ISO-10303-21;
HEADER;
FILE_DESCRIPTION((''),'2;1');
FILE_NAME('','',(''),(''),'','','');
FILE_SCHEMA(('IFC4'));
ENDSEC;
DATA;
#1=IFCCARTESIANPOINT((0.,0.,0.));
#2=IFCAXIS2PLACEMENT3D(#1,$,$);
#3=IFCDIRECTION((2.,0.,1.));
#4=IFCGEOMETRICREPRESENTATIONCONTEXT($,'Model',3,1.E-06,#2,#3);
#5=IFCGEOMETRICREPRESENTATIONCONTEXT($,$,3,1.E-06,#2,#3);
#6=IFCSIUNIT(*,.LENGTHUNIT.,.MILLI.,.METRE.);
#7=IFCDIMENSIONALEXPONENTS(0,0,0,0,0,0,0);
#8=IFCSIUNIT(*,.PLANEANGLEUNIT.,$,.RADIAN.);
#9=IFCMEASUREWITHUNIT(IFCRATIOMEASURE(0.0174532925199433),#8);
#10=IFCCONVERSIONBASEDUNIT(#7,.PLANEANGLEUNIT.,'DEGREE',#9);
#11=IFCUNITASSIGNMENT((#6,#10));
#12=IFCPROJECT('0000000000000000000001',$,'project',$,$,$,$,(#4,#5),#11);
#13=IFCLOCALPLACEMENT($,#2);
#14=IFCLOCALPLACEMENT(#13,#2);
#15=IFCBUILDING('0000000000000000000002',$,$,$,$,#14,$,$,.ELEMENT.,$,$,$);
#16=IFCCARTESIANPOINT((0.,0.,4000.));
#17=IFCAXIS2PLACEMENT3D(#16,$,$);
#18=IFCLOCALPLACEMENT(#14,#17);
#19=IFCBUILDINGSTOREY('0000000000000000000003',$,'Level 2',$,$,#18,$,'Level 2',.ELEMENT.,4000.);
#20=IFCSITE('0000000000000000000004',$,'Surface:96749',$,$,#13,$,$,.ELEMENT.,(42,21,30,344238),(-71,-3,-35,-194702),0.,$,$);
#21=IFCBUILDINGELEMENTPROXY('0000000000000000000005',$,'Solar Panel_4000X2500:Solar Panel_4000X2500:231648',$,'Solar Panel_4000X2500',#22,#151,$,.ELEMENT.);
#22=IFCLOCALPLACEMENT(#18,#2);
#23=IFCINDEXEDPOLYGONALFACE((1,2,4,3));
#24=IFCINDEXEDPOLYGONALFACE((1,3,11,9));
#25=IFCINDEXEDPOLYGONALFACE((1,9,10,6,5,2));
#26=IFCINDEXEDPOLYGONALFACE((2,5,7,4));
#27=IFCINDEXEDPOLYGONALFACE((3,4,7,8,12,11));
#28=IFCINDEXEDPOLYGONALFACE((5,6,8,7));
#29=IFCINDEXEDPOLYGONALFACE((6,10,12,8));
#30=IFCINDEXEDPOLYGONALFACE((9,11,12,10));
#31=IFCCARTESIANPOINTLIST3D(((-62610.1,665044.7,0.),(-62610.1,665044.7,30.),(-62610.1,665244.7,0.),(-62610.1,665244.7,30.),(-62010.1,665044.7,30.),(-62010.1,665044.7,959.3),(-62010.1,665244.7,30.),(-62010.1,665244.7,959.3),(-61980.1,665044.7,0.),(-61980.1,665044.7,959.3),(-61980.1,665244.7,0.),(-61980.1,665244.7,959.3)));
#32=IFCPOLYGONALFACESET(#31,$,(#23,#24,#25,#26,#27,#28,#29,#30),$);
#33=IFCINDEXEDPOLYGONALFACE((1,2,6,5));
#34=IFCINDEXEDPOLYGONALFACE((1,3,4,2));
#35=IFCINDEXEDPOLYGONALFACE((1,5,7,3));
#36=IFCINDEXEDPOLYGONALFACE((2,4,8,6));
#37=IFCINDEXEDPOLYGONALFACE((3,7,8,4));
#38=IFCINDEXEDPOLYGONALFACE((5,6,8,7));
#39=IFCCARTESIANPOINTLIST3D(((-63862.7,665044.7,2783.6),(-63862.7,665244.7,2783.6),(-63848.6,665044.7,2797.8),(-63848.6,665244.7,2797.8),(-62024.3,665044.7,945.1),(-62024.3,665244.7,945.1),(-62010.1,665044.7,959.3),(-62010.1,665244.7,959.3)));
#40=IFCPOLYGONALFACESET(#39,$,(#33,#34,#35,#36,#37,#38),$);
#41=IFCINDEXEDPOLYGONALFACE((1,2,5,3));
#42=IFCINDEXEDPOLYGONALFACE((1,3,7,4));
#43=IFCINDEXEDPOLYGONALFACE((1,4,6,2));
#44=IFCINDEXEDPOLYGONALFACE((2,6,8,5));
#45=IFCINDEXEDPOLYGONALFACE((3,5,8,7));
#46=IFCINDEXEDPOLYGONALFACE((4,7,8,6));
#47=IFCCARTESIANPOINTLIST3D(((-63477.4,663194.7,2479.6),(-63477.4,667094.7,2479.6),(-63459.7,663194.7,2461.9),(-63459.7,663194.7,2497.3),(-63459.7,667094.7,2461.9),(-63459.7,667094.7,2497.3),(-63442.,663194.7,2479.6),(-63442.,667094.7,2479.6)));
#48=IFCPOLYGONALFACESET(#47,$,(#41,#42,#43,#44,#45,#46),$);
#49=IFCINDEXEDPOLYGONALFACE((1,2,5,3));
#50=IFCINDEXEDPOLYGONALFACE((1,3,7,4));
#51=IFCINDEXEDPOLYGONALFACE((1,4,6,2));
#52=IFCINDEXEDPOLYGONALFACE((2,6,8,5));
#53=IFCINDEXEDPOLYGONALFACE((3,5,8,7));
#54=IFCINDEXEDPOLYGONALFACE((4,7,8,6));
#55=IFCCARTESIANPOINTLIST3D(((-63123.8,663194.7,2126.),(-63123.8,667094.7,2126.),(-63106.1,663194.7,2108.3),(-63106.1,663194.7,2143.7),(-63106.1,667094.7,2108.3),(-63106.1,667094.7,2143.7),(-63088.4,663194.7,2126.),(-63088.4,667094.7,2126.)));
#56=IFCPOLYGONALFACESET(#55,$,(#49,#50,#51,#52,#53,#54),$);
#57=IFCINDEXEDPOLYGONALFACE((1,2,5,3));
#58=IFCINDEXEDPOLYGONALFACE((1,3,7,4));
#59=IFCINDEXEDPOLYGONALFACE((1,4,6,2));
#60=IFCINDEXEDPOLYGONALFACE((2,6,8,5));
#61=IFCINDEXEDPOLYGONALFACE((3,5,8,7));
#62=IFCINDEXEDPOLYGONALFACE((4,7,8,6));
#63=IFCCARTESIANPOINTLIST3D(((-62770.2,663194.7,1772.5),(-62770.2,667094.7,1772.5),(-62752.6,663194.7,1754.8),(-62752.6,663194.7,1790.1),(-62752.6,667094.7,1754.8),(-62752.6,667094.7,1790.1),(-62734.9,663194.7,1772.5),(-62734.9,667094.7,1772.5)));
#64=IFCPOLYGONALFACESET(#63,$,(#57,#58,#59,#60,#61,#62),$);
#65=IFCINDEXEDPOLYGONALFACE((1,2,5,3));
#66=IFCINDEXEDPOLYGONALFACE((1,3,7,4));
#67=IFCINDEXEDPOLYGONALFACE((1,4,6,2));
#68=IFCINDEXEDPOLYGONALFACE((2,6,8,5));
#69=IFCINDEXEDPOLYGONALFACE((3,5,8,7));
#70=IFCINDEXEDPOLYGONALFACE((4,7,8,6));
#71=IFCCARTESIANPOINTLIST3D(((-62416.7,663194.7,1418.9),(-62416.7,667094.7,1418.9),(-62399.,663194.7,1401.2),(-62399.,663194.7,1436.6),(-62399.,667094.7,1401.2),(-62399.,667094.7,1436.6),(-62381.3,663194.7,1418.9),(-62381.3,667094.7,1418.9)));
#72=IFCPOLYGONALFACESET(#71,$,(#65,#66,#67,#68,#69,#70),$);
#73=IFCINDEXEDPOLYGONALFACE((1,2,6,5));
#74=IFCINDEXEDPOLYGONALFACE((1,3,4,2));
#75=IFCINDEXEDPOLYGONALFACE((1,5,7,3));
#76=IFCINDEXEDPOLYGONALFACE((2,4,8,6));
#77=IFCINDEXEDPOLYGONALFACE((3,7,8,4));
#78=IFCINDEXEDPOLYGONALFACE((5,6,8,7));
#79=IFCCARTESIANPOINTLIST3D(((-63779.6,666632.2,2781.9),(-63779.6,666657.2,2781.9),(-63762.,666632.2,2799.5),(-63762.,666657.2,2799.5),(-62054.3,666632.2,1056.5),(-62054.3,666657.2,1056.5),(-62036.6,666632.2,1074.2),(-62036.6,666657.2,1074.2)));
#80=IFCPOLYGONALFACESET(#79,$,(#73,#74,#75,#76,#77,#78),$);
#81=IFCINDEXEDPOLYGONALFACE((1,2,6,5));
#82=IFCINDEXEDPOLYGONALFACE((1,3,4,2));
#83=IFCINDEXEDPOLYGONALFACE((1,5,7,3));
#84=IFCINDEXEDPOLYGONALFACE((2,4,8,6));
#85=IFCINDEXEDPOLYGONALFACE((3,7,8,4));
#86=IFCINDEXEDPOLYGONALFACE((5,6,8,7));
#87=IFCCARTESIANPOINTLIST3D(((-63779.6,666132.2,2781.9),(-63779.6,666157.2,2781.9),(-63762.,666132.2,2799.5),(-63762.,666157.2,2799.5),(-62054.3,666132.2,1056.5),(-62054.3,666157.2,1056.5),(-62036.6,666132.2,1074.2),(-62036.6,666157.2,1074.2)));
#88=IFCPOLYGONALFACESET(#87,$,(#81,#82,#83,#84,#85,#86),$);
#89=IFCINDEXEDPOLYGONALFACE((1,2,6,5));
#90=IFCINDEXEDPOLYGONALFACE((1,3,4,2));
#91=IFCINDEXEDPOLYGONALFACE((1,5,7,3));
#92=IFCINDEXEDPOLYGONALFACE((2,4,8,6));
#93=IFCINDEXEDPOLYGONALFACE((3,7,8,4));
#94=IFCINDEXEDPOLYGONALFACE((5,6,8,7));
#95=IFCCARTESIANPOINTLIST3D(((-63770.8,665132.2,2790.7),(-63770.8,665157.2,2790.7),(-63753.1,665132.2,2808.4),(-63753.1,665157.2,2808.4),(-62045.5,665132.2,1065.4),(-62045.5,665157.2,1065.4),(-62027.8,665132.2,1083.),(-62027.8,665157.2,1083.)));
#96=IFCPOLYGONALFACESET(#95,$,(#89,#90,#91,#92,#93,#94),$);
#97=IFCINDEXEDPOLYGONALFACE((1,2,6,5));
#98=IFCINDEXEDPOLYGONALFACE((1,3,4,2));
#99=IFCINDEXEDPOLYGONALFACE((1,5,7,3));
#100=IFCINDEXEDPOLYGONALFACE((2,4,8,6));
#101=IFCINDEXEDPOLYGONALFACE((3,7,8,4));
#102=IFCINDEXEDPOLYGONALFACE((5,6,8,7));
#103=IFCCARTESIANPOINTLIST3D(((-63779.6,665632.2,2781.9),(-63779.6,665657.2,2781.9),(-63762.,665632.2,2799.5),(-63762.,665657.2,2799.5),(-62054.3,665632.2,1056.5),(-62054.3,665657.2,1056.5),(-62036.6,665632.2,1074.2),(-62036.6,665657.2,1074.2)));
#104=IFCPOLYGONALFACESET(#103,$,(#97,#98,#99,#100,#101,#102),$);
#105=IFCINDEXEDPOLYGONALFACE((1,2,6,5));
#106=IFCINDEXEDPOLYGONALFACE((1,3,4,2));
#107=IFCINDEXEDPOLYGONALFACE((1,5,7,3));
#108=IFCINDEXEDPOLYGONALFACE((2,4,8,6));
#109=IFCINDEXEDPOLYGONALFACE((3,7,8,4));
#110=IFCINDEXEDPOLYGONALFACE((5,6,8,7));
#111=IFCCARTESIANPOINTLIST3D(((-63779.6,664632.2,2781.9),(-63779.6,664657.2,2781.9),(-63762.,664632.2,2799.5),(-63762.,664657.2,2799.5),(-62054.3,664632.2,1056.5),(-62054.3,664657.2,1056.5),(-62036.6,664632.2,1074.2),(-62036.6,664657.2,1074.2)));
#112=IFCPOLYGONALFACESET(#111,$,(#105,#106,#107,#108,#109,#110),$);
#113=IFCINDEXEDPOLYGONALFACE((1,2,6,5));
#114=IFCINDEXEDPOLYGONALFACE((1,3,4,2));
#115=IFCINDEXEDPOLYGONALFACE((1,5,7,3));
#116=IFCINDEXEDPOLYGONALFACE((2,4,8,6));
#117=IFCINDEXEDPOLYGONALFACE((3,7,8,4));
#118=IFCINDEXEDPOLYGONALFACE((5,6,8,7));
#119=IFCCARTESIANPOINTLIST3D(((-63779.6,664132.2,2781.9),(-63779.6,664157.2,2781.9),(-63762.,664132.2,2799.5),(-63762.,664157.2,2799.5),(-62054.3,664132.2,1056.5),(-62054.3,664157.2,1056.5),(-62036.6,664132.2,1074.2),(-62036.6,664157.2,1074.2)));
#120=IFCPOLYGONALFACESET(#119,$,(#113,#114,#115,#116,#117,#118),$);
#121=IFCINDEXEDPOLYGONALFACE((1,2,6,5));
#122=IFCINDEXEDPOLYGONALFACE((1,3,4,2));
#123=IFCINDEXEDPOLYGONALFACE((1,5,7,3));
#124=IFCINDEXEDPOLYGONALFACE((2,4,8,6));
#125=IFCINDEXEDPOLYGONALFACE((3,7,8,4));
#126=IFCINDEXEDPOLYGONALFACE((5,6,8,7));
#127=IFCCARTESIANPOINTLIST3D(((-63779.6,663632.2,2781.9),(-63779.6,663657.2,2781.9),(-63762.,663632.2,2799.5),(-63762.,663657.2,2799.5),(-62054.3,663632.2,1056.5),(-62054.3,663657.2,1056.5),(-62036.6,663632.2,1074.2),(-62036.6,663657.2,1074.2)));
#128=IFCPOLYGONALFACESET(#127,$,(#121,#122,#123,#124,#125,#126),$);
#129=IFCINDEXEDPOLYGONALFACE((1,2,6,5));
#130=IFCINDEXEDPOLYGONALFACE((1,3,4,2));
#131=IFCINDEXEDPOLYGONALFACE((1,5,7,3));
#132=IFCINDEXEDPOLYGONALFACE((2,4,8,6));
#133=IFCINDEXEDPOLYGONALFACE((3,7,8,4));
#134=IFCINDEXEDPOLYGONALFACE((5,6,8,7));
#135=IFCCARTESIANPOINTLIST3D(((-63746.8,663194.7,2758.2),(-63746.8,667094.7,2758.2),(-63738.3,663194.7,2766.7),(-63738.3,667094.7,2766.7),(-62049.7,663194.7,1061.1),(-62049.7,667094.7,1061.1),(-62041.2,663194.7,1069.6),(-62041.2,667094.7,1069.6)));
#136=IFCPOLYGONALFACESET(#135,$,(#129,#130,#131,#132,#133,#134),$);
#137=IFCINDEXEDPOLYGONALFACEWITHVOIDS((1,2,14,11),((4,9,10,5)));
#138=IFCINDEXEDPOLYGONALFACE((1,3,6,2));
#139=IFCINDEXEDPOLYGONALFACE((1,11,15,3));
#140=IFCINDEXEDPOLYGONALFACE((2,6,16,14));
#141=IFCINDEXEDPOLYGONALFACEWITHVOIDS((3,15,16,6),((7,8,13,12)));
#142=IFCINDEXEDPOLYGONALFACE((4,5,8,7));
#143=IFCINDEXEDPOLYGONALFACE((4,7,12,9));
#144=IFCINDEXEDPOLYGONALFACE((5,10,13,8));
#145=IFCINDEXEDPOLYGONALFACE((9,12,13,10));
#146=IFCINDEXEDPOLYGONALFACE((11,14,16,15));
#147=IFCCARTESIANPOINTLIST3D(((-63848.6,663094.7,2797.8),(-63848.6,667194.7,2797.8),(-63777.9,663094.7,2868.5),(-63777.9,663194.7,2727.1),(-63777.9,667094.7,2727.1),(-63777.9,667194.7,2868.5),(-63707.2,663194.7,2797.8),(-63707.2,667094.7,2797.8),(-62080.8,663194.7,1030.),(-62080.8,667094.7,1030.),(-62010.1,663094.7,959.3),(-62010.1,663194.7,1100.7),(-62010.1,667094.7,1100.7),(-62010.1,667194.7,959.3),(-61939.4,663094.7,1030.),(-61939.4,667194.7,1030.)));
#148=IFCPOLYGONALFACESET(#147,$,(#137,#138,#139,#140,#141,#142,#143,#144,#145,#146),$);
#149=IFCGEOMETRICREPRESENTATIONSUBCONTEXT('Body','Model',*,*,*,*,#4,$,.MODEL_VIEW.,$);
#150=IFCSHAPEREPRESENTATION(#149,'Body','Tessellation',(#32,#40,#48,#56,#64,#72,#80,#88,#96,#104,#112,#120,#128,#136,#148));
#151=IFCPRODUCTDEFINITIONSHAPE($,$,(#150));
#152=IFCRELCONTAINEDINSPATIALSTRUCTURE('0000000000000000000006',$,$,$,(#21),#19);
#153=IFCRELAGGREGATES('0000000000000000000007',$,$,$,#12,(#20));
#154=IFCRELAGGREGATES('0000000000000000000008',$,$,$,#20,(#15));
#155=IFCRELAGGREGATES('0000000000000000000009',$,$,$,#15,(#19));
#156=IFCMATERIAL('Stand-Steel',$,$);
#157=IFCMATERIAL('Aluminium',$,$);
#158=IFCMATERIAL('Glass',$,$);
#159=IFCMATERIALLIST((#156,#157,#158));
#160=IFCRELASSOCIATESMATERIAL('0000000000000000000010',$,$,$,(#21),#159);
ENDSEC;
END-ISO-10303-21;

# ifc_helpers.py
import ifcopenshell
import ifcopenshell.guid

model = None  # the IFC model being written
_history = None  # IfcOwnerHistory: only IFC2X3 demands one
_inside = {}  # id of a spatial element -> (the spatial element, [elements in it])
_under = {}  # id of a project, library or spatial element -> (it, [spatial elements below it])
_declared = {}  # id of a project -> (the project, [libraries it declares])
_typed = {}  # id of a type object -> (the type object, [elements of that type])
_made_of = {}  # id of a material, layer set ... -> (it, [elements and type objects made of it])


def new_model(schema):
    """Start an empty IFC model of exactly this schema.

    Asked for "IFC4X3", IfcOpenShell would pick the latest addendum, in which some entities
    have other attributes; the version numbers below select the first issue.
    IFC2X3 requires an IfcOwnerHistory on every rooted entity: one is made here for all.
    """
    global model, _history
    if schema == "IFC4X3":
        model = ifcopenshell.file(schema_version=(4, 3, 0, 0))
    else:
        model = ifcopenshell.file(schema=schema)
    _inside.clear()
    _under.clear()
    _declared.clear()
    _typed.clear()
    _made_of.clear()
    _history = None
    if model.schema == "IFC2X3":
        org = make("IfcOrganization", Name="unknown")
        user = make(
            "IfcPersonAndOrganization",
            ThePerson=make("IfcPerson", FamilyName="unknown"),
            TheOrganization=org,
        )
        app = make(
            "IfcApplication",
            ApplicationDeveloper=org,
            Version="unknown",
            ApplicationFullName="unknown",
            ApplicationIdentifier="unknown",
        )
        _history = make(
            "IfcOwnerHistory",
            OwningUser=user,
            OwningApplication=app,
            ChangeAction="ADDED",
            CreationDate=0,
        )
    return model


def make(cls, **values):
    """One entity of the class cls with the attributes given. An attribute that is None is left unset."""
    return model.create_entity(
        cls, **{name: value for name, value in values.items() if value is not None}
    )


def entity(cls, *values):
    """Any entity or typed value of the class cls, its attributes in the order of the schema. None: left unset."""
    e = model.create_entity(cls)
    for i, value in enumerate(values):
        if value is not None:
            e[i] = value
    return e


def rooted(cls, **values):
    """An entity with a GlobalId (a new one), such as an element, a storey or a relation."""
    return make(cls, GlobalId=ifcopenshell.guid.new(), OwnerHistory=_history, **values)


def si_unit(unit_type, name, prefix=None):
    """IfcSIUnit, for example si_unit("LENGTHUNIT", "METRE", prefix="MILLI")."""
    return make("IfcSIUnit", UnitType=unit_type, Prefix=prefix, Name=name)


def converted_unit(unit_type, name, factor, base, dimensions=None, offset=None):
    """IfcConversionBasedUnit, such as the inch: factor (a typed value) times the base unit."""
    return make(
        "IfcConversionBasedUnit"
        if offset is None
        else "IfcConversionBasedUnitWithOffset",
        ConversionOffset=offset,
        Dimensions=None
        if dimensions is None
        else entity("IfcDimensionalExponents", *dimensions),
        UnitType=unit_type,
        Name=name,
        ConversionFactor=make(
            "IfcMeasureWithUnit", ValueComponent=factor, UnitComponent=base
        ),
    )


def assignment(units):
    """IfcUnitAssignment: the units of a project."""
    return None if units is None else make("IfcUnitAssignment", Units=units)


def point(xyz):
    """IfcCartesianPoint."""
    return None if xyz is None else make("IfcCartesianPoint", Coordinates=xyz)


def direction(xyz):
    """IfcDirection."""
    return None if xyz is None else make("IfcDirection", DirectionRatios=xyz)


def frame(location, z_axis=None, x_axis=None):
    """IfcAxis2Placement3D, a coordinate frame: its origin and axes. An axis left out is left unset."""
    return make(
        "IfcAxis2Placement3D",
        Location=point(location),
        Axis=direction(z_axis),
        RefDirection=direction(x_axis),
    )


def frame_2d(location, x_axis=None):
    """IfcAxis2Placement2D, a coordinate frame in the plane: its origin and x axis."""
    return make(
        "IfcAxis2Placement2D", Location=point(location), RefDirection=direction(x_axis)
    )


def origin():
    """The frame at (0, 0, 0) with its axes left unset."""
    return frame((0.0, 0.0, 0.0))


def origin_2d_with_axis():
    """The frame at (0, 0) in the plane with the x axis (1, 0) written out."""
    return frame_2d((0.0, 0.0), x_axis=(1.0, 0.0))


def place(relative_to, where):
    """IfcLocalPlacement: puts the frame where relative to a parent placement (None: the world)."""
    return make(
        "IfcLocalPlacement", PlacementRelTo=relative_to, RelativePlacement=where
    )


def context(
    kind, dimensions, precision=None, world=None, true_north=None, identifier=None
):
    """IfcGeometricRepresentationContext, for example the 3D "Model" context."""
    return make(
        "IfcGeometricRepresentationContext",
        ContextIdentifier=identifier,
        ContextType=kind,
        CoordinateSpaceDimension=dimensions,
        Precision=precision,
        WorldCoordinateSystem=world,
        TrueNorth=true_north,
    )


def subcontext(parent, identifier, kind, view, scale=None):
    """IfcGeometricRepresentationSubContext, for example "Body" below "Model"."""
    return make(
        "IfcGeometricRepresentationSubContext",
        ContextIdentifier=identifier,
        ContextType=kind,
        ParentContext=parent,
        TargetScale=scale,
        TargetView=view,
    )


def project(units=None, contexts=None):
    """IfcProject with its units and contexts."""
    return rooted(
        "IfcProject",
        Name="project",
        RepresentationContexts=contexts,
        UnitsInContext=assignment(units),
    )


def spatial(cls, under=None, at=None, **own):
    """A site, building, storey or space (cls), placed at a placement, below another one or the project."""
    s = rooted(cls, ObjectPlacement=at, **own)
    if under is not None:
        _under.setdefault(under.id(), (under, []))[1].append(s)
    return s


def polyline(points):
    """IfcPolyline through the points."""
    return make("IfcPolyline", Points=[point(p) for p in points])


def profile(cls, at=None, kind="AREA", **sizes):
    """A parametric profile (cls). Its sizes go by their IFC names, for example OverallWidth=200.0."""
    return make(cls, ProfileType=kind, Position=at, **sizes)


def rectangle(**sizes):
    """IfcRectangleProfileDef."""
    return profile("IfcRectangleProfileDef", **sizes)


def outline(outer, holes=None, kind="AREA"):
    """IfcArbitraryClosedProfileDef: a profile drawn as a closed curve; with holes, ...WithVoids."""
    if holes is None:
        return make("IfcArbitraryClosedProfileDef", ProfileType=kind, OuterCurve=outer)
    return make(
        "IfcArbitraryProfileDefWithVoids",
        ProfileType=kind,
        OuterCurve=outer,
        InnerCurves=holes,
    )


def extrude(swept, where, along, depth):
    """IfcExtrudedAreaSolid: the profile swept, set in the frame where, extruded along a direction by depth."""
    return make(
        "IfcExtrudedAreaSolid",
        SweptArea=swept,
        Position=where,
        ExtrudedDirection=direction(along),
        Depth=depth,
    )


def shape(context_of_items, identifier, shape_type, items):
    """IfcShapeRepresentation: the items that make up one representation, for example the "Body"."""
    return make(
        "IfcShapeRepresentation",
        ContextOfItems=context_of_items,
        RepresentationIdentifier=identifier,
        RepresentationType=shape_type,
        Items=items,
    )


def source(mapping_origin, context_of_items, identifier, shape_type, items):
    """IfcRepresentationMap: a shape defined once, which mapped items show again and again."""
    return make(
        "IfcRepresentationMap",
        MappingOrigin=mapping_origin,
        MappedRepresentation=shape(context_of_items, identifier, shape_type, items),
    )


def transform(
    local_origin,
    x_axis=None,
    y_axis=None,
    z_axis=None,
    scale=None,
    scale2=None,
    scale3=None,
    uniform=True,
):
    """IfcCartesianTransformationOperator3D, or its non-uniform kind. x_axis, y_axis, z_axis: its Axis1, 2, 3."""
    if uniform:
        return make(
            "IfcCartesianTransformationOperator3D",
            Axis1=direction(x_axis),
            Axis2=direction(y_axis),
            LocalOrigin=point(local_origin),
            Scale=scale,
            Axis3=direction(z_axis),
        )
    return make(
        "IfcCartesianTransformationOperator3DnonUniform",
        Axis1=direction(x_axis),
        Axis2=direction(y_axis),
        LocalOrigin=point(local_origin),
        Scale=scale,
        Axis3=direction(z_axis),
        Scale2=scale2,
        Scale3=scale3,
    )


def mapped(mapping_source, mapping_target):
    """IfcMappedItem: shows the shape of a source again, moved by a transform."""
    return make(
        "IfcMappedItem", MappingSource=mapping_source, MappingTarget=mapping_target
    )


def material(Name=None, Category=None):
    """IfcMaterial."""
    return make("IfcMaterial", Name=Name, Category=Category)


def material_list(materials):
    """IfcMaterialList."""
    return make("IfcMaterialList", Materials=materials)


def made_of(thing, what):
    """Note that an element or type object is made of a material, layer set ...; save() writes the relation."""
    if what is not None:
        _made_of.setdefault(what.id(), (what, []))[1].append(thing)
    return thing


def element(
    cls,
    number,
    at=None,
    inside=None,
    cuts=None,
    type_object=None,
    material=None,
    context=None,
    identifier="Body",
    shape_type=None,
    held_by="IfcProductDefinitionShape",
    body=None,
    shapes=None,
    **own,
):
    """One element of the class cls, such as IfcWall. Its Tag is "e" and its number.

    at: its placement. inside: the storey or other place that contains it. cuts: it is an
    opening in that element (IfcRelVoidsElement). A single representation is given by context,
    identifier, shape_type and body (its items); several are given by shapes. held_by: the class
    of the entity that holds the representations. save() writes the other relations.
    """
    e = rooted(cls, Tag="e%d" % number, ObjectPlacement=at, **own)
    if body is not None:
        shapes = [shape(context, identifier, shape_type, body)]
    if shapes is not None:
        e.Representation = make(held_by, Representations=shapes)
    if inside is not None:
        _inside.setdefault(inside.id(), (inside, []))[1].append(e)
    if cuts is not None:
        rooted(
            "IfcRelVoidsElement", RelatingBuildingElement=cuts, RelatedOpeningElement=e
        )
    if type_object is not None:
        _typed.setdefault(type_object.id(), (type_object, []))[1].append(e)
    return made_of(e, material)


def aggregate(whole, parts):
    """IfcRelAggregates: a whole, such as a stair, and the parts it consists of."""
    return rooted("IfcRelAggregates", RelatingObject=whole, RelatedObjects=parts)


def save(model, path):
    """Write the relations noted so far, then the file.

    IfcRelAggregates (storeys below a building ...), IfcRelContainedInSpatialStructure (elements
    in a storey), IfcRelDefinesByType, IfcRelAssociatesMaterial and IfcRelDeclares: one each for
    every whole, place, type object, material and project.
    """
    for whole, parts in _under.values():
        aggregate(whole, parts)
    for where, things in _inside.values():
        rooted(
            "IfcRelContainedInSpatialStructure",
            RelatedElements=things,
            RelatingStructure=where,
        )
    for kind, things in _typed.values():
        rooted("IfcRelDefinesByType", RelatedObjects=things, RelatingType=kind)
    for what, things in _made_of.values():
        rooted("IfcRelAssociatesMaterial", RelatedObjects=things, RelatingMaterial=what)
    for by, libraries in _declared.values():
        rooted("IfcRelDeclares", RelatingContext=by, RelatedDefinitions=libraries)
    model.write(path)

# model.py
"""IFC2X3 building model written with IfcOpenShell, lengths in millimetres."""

from ifc_helpers import new_model, entity, si_unit, converted_unit, direction, frame, frame_2d, origin, origin_2d_with_axis, place, context, subcontext, project, spatial, polyline, rectangle, outline, extrude, source, transform, mapped, material, material_list, element, save


model = new_model("IFC2X3")

# Units and contexts
model_context = context("Model", 3, precision=1e-06, world=origin(), true_north=direction((2.0, 0.0, 1.0)))
context_of_model = context(None, 3, precision=1e-06, world=origin(), true_north=direction((2.0, 0.0, 1.0)))
body_context = subcontext(model_context, "Body", "Model", "MODEL_VIEW")
ifc_project = project(units=[si_unit("LENGTHUNIT", "METRE", prefix="MILLI"), converted_unit("PLANEANGLEUNIT", "DEGREE", entity("IfcRatioMeasure", 0.0174532925199433), si_unit("PLANEANGLEUNIT", "RADIAN"), dimensions=[0, 0, 0, 0, 0, 0, 0])], contexts=[model_context, context_of_model])

# Site, building, storey
site_placement = place(None, origin())
site = spatial("IfcSite", under=ifc_project, at=site_placement, Name="Surface:96749", CompositionType="ELEMENT", RefLatitude=(42, 21, 30, 344238), RefLongitude=(-71, -3, -35, -194702), RefElevation=0.0)
building_placement = place(site_placement, origin())
building = spatial("IfcBuilding", under=site, at=building_placement, CompositionType="ELEMENT")
storey_placement = place(building_placement, frame((0.0, 0.0, 4000.0)))
storey = spatial("IfcBuildingStorey", under=building, at=storey_placement, Name="Level 2", LongName="Level 2", CompositionType="ELEMENT", Elevation=4000.0)

# Building element proxy
ifc_material_1 = material(Name="Stand-Steel")
ifc_material_2 = material(Name="Aluminium")
ifc_material_3 = material(Name="Glass")
shared_shape = source(origin(), body_context, "Body", "SweptSolid", [
    extrude(outline(polyline([(-629.5, -220.0), (329.8, -220.0), (329.8, 410.0), (299.8, 410.0), (299.8, -190.0), (-629.5, -190.0), (-629.5, -220.0)])), frame((-190.0, -100.0, 299.8), z_axis=(0.0, 1.0, 0.0), x_axis=(0.0, 0.0, -1.0)), (0.0, 0.0, 1.0), 200.0),
    extrude(rectangle(XDim=20.0, YDim=200.0, at=frame_2d((0.0, 0.0), x_axis=(0.0, 1.0))), frame((-7.1, 0.0, 922.2), z_axis=(-0.707107, 0.0, 0.707107), x_axis=(0.0, 1.0, 0.0)), (0.0, 0.0, 1.0), 2600.0),
    extrude(rectangle(XDim=25.0, YDim=25.0, at=frame_2d((0.0, 0.0), x_axis=(1.0, 0.0))), frame((-1449.6, -1950.0, 2449.6), z_axis=(0.0, 1.0, 0.0), x_axis=(-0.707107, 0.0, -0.707107)), (0.0, 0.0, 1.0), 3900.0),
    extrude(rectangle(XDim=25.0, YDim=25.0, at=origin_2d_with_axis()), frame((-1096.0, -1950.0, 2096.0), z_axis=(0.0, 1.0, 0.0), x_axis=(-0.707107, 0.0, -0.707107)), (0.0, 0.0, 1.0), 3900.0),
    extrude(rectangle(XDim=25.0, YDim=25.0, at=origin_2d_with_axis()), frame((-742.5, -1950.0, 1742.5), z_axis=(0.0, 1.0, 0.0), x_axis=(-0.707107, 0.0, -0.707107)), (0.0, 0.0, 1.0), 3900.0),
    extrude(rectangle(XDim=25.0, YDim=25.0, at=frame_2d((0.0, 0.0), x_axis=(1.0, 0.0))), frame((-388.9, -1950.0, 1388.9), z_axis=(0.0, 1.0, 0.0), x_axis=(-0.707107, 0.0, -0.707107)), (0.0, 0.0, 1.0), 3900.0),
    extrude(rectangle(XDim=25.0, YDim=25.0, at=frame_2d((0.0, 0.0), x_axis=(0.0, 1.0))), frame((-35.4, 1500.0, 1035.4), z_axis=(-0.707107, 0.0, 0.707107), x_axis=(0.0, 1.0, 0.0)), (0.0, 0.0, 1.0), 2440.0),
    extrude(rectangle(XDim=25.0, YDim=25.0, at=frame_2d((0.0, 0.0), x_axis=(0.0, 1.0))), frame((-35.4, 1000.0, 1035.4), z_axis=(-0.707107, 0.0, 0.707107), x_axis=(0.0, 1.0, 0.0)), (0.0, 0.0, 1.0), 2440.0),
    extrude(rectangle(XDim=25.0, YDim=25.0, at=frame_2d((0.0, 0.0), x_axis=(0.0, 1.0))), frame((-26.5, 0.0, 1044.2), z_axis=(-0.707107, 0.0, 0.707107), x_axis=(0.0, -1.0, 0.0)), (0.0, 0.0, 1.0), 2440.0),
    extrude(rectangle(XDim=25.0, YDim=25.0, at=frame_2d((0.0, 0.0), x_axis=(0.0, 1.0))), frame((-35.4, 500.0, 1035.4), z_axis=(-0.707107, 0.0, 0.707107), x_axis=(0.0, 1.0, 0.0)), (0.0, 0.0, 1.0), 2440.0),
    extrude(rectangle(XDim=25.0, YDim=25.0, at=frame_2d((0.0, 0.0), x_axis=(0.0, 1.0))), frame((-35.4, -500.0, 1035.4), z_axis=(-0.707107, 0.0, 0.707107), x_axis=(0.0, 1.0, 0.0)), (0.0, 0.0, 1.0), 2440.0),
    extrude(rectangle(XDim=25.0, YDim=25.0, at=frame_2d((0.0, 0.0), x_axis=(0.0, 1.0))), frame((-35.4, -1000.0, 1035.4), z_axis=(-0.707107, 0.0, 0.707107), x_axis=(0.0, 1.0, 0.0)), (0.0, 0.0, 1.0), 2440.0),
    extrude(rectangle(XDim=25.0, YDim=25.0, at=frame_2d((0.0, 0.0), x_axis=(0.0, 1.0))), frame((-35.4, -1500.0, 1035.4), z_axis=(-0.707107, 0.0, 0.707107), x_axis=(0.0, 1.0, 0.0)), (0.0, 0.0, 1.0), 2440.0),
    extrude(rectangle(XDim=2400.0, YDim=12.0, at=frame_2d((0.0, 0.0), x_axis=(1.0, 0.0))), frame((-883.9, -1950.0, 1883.9), z_axis=(0.0, 1.0, 0.0), x_axis=(0.707107, 0.0, -0.707107)), (0.0, 0.0, 1.0), 3900.0),
    extrude(outline(polyline([(-2050.0, -1300.0), (2050.0, -1300.0), (2050.0, 1300.0), (-2050.0, 1300.0), (-2050.0, -1300.0)]), holes=[polyline([(1950.0, -1200.0), (-1950.0, -1200.0), (-1950.0, 1200.0), (1950.0, 1200.0), (1950.0, -1200.0)])]), frame((-919.2, 0.0, 1848.5), z_axis=(0.707107, 0.0, 0.707107), x_axis=(0.0, 1.0, 0.0)), (0.0, 0.0, 1.0), 100.0),
])
ifc_material_list_1 = material_list([ifc_material_1, ifc_material_2, ifc_material_3])
proxy_1_placement = place(storey_placement, frame((-62010.1, 665144.7, 30.0)))
element("IfcBuildingElementProxy", 1, at=proxy_1_placement, inside=storey, material=ifc_material_list_1, Name="Solar Panel_4000X2500:Solar Panel_4000X2500:231648", ObjectType="Solar Panel_4000X2500", CompositionType="ELEMENT", context=body_context, shape_type="MappedRepresentation", body=[
    mapped(shared_shape, transform((0.0, 0.0, 0.0), scale=1.0)),
])

save(model, "model.ifc")
